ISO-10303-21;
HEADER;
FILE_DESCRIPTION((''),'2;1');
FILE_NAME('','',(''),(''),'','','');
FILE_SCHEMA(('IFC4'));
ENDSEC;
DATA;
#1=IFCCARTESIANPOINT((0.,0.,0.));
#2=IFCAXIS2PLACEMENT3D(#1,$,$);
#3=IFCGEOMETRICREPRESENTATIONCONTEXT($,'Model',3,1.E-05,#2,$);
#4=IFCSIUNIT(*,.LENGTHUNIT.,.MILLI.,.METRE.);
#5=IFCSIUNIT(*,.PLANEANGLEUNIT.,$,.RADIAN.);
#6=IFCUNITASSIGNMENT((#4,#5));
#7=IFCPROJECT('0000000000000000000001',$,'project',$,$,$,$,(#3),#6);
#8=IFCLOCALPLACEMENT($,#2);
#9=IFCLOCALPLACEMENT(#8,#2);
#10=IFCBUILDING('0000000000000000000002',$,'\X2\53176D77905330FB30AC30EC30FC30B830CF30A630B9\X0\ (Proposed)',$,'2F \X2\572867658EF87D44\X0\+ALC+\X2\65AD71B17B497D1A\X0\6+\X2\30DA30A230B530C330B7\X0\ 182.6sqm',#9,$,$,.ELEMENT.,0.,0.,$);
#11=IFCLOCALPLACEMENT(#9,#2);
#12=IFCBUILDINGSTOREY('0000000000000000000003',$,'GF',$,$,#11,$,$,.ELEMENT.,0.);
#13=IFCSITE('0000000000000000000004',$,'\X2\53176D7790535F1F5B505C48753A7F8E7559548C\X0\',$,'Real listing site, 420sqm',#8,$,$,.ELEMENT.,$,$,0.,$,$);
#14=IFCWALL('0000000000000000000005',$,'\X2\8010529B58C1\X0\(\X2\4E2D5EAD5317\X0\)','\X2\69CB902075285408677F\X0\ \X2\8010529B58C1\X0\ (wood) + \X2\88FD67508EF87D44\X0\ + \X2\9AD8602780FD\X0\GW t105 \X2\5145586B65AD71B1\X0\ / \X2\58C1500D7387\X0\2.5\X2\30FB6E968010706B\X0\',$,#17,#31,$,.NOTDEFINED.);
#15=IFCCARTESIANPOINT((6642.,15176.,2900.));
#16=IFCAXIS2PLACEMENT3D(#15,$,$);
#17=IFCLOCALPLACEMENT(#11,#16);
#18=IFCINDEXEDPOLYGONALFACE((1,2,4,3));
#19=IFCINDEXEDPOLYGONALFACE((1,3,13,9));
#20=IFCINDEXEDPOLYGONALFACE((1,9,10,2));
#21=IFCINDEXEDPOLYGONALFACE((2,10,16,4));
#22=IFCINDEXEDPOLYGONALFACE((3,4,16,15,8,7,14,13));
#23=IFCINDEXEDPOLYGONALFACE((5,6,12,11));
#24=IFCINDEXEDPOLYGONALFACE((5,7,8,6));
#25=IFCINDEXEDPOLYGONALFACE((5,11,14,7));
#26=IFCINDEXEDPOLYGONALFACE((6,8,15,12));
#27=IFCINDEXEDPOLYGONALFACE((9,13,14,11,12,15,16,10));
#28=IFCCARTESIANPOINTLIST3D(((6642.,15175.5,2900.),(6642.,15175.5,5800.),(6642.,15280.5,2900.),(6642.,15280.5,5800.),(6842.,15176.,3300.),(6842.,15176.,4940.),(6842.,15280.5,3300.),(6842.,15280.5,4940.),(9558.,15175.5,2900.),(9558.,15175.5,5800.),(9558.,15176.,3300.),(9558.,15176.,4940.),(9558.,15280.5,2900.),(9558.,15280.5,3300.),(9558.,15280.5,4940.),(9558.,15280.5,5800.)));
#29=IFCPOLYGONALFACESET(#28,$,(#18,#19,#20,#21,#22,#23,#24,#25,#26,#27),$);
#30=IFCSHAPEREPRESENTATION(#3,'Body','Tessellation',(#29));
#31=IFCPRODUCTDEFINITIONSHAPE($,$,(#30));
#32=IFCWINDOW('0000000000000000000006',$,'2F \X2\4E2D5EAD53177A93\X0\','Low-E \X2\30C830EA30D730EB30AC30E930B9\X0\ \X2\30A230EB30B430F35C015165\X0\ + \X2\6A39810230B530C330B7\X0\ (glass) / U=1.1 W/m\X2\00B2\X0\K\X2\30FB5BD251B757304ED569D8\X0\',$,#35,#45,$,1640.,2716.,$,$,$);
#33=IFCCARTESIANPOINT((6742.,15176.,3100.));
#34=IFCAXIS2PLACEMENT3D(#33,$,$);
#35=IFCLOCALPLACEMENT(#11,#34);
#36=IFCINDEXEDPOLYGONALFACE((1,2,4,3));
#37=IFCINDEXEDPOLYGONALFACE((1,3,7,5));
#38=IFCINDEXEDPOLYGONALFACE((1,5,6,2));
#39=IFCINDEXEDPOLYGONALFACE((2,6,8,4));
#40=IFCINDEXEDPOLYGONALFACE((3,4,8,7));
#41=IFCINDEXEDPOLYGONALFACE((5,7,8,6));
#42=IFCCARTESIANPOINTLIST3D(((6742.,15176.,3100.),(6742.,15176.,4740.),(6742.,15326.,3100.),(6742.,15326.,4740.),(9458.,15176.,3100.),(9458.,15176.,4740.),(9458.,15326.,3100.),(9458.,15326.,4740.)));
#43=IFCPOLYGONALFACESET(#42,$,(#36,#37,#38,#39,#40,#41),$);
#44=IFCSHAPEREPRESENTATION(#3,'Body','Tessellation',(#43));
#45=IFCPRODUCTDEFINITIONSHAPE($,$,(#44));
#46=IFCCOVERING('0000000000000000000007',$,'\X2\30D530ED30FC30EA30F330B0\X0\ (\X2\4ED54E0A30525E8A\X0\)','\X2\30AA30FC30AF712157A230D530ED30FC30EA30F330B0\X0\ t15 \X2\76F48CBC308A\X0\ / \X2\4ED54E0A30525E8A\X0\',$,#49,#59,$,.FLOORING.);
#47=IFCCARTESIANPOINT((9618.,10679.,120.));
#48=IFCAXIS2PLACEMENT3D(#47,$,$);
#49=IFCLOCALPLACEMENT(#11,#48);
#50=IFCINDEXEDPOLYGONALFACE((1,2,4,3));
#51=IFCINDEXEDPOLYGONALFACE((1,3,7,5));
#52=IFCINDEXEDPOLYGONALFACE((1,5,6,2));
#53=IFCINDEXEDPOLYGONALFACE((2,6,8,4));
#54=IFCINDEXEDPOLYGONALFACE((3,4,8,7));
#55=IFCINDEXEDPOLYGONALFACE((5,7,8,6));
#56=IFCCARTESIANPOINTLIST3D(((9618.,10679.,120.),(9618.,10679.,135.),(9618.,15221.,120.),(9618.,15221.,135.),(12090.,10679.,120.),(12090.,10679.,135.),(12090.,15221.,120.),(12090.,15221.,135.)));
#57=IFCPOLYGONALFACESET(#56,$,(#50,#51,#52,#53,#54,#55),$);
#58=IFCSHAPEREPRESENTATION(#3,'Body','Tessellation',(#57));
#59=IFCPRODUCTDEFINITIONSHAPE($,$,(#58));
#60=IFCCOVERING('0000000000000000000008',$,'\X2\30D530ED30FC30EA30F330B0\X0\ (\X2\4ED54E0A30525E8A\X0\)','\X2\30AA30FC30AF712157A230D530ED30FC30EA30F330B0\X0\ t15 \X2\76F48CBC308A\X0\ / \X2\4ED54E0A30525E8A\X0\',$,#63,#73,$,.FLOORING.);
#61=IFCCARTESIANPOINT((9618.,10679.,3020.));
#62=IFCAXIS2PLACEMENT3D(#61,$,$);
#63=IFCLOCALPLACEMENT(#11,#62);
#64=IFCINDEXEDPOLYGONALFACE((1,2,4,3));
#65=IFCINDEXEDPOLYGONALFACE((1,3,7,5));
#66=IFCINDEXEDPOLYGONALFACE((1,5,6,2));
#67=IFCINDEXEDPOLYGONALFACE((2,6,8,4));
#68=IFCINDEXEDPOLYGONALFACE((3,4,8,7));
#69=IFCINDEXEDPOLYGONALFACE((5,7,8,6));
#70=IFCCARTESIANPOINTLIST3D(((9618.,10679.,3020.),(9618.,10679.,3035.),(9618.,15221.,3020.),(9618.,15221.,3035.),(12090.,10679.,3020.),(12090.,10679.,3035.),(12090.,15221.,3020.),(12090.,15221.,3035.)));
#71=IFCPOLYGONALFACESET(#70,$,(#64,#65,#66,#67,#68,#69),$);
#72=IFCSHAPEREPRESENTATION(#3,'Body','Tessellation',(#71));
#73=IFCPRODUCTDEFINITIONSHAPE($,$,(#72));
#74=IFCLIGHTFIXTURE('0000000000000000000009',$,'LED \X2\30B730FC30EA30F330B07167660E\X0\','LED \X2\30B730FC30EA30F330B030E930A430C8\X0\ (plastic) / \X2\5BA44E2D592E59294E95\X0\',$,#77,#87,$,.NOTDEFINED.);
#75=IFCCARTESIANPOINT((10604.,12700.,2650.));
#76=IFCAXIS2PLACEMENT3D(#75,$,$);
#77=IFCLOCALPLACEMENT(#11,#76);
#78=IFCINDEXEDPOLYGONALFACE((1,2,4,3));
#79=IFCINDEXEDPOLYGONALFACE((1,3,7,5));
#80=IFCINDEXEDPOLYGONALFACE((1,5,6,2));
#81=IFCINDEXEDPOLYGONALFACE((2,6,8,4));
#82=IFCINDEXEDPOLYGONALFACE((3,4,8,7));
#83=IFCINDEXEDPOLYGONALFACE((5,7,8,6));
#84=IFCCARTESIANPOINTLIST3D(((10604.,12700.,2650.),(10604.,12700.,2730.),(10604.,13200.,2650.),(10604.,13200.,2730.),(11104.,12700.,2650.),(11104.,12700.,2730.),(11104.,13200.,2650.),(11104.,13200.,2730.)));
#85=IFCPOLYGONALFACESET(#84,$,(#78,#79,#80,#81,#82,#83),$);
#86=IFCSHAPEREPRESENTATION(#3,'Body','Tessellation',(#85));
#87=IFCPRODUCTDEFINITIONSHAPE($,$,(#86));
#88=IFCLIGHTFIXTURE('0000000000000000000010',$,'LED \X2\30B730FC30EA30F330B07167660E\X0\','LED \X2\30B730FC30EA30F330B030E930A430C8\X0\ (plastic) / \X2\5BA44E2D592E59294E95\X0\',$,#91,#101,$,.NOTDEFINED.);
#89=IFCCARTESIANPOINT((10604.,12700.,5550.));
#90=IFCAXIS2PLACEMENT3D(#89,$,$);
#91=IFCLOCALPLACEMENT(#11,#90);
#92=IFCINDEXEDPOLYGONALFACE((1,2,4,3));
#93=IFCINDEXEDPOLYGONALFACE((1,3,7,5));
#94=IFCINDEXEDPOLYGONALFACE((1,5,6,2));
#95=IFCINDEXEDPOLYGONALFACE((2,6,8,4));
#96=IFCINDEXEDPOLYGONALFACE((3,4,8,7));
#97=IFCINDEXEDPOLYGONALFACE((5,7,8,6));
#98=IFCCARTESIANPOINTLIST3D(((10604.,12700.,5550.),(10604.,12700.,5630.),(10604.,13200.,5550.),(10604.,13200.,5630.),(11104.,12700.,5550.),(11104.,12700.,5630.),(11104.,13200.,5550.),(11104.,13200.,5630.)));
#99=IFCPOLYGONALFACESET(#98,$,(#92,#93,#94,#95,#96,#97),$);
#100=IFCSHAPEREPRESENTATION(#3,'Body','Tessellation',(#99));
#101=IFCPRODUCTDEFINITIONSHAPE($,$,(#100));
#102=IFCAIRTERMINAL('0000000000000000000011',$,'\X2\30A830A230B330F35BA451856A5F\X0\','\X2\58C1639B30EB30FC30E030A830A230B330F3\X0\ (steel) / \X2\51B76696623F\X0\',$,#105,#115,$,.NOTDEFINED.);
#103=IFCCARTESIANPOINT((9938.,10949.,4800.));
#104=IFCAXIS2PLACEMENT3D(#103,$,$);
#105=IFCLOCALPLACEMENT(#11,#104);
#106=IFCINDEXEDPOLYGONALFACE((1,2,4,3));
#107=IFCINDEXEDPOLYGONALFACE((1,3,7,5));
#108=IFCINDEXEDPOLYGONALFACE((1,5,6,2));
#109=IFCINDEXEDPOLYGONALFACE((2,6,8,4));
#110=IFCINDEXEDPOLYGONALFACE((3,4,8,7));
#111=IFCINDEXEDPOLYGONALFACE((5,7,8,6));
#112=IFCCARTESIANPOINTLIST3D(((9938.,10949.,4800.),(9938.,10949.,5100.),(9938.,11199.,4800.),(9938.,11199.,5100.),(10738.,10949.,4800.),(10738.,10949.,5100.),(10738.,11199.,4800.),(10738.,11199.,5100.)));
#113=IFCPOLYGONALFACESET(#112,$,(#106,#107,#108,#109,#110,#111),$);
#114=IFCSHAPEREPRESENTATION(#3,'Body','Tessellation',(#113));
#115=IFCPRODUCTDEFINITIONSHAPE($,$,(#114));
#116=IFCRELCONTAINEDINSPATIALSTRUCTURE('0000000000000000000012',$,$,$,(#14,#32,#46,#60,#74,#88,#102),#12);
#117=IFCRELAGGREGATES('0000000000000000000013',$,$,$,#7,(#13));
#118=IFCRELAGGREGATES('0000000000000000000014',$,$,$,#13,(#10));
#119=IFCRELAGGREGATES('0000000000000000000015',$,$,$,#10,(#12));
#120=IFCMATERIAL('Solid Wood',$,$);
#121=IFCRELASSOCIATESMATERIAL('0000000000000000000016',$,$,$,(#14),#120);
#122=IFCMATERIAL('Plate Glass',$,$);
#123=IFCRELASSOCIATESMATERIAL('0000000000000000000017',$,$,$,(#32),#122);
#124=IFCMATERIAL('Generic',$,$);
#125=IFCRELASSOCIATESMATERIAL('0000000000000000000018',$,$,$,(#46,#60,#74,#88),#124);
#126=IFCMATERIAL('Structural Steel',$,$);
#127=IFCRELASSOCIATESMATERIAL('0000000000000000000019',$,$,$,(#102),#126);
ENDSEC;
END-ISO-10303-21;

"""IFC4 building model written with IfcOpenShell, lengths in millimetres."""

from ifc_helpers import new_model, si_unit, frame, frame_2d, origin, place, context, project, spatial, rectangle, extrude, material, element, fill, save


model = new_model("IFC4")

# Units and contexts
model_context = context("Model", 3, precision=1e-05, world=origin())
ifc_project = project(units=[si_unit("LENGTHUNIT", "METRE", prefix="MILLI"), si_unit("PLANEANGLEUNIT", "RADIAN")], contexts=[model_context])

# Site, building, storey
site_placement = place(None, origin())
site = spatial("IfcSite", under=ifc_project, at=site_placement, Name="北海道弟子屈町美留和", ObjectType="Real listing site, 420sqm", CompositionType="ELEMENT", RefElevation=0.0)
building_placement = place(site_placement, origin())
building = spatial("IfcBuilding", under=site, at=building_placement, Name="北海道・ガレージハウス (Proposed)", ObjectType="2F 在来軸組+ALC+断熱等級6+ペアサッシ 182.6sqm", CompositionType="ELEMENT", ElevationOfRefHeight=0.0, ElevationOfTerrain=0.0)
storey_placement = place(building_placement, origin())
storey = spatial("IfcBuildingStorey", under=building, at=storey_placement, Name="GF", CompositionType="ELEMENT", Elevation=0.0)

# Shared definitions
ifc_material_1 = material(Name="Solid Wood")
ifc_material_2 = material(Name="Structural Steel")

# Wall, opening, window
ifc_material_3 = material(Name="Plate Glass")
wall_1_placement = place(storey_placement, frame((6642.0, 15176.0, 2900.0)))
wall_1 = element("IfcWall", 1, at=wall_1_placement, inside=storey, material=ifc_material_1, Name="耐力壁(中庭北)", Description="構造用合板 耐力壁 (wood) + 製材軸組 + 高性能GW t105 充填断熱 / 壁倍率2.5・準耐火", PredefinedType="NOTDEFINED", context=model_context, shape_type="SweptSolid", body=[
    extrude(rectangle(XDim=2916.0, YDim=105.0, at=frame_2d((1458.0, 52.0))), frame((6642.0, 15176.0, 2900.0)), (0.0, 0.0, 1.0), 2900.0),
])
opening_1_placement = place(storey_placement, frame((6742.0, 15176.0, 3100.0)))
opening_1 = element("IfcOpeningElement", 2, at=opening_1_placement, cuts=wall_1, PredefinedType="NOTDEFINED", context=model_context, shape_type="SweptSolid", body=[
    extrude(rectangle(XDim=2716.0, YDim=150.0, at=frame_2d((1358.0, 75.0))), frame((6742.0, 15176.0, 3100.0)), (0.0, 0.0, 1.0), 1640.0),
])
window_1_placement = place(storey_placement, frame((6742.0, 15176.0, 3100.0)))
window_1 = element("IfcWindow", 3, at=window_1_placement, inside=storey, material=ifc_material_3, Name="2F 中庭北窓", Description="Low-E トリプルガラス アルゴン封入 + 樹脂サッシ (glass) / U=1.1 W/m²K・寒冷地仕様", OverallHeight=1640.0, OverallWidth=2716.0, context=model_context, shape_type="SweptSolid", body=[
    extrude(rectangle(XDim=2716.0, YDim=150.0, at=frame_2d((1358.0, 75.0))), frame((6742.0, 15176.0, 3100.0)), (0.0, 0.0, 1.0), 1640.0),
])
fill(opening_1, window_1)

# Coverings
ifc_material_4 = material(Name="Generic")
covering_1_placement = place(storey_placement, frame((9618.0, 10679.0, 120.0)))
element("IfcCovering", 4, at=covering_1_placement, inside=storey, material=ifc_material_4, Name="フローリング (仕上げ床)", Description="オーク無垢フローリング t15 直貼り / 仕上げ床", PredefinedType="FLOORING", context=model_context, shape_type="SweptSolid", body=[
    extrude(rectangle(XDim=2472.0, YDim=4542.0, at=frame_2d((1236.0, 2271.0))), frame((9618.0, 10679.0, 120.0)), (0.0, 0.0, 1.0), 15.0),
])
covering_2_placement = place(storey_placement, frame((9618.0, 10679.0, 3020.0)))
element("IfcCovering", 5, at=covering_2_placement, inside=storey, material=ifc_material_4, Name="フローリング (仕上げ床)", Description="オーク無垢フローリング t15 直貼り / 仕上げ床", PredefinedType="FLOORING", context=model_context, shape_type="SweptSolid", body=[
    extrude(rectangle(XDim=2472.0, YDim=4542.0, at=frame_2d((1236.0, 2271.0))), frame((9618.0, 10679.0, 3020.0)), (0.0, 0.0, 1.0), 15.0),
])

# Light fixtures
light_fixture_1_placement = place(storey_placement, frame((10604.0, 12700.0, 2650.0)))
element("IfcLightFixture", 6, at=light_fixture_1_placement, inside=storey, material=ifc_material_4, Name="LED シーリング照明", Description="LED シーリングライト (plastic) / 室中央天井", PredefinedType="NOTDEFINED", context=model_context, shape_type="SweptSolid", body=[
    extrude(rectangle(XDim=500.0, YDim=500.0, at=frame_2d((250.0, 250.0))), frame((10604.0, 12700.0, 2650.0)), (0.0, 0.0, 1.0), 80.0),
])
light_fixture_2_placement = place(storey_placement, frame((10604.0, 12700.0, 5550.0)))
element("IfcLightFixture", 7, at=light_fixture_2_placement, inside=storey, material=ifc_material_4, Name="LED シーリング照明", Description="LED シーリングライト (plastic) / 室中央天井", PredefinedType="NOTDEFINED", context=model_context, shape_type="SweptSolid", body=[
    extrude(rectangle(XDim=500.0, YDim=500.0, at=frame_2d((250.0, 250.0))), frame((10604.0, 12700.0, 5550.0)), (0.0, 0.0, 1.0), 80.0),
])

# Air terminal
air_terminal_placement = place(storey_placement, frame((9938.0, 10949.0, 4800.0)))
element("IfcAirTerminal", 8, at=air_terminal_placement, inside=storey, material=ifc_material_2, Name="エアコン室内機", Description="壁掛ルームエアコン (steel) / 冷暖房", PredefinedType="NOTDEFINED", context=model_context, shape_type="SweptSolid", body=[
    extrude(rectangle(XDim=800.0, YDim=250.0, at=frame_2d((400.0, 125.0))), frame((9938.0, 10949.0, 4800.0)), (0.0, 0.0, 1.0), 300.0),
])

save(model, "model.ifc")
